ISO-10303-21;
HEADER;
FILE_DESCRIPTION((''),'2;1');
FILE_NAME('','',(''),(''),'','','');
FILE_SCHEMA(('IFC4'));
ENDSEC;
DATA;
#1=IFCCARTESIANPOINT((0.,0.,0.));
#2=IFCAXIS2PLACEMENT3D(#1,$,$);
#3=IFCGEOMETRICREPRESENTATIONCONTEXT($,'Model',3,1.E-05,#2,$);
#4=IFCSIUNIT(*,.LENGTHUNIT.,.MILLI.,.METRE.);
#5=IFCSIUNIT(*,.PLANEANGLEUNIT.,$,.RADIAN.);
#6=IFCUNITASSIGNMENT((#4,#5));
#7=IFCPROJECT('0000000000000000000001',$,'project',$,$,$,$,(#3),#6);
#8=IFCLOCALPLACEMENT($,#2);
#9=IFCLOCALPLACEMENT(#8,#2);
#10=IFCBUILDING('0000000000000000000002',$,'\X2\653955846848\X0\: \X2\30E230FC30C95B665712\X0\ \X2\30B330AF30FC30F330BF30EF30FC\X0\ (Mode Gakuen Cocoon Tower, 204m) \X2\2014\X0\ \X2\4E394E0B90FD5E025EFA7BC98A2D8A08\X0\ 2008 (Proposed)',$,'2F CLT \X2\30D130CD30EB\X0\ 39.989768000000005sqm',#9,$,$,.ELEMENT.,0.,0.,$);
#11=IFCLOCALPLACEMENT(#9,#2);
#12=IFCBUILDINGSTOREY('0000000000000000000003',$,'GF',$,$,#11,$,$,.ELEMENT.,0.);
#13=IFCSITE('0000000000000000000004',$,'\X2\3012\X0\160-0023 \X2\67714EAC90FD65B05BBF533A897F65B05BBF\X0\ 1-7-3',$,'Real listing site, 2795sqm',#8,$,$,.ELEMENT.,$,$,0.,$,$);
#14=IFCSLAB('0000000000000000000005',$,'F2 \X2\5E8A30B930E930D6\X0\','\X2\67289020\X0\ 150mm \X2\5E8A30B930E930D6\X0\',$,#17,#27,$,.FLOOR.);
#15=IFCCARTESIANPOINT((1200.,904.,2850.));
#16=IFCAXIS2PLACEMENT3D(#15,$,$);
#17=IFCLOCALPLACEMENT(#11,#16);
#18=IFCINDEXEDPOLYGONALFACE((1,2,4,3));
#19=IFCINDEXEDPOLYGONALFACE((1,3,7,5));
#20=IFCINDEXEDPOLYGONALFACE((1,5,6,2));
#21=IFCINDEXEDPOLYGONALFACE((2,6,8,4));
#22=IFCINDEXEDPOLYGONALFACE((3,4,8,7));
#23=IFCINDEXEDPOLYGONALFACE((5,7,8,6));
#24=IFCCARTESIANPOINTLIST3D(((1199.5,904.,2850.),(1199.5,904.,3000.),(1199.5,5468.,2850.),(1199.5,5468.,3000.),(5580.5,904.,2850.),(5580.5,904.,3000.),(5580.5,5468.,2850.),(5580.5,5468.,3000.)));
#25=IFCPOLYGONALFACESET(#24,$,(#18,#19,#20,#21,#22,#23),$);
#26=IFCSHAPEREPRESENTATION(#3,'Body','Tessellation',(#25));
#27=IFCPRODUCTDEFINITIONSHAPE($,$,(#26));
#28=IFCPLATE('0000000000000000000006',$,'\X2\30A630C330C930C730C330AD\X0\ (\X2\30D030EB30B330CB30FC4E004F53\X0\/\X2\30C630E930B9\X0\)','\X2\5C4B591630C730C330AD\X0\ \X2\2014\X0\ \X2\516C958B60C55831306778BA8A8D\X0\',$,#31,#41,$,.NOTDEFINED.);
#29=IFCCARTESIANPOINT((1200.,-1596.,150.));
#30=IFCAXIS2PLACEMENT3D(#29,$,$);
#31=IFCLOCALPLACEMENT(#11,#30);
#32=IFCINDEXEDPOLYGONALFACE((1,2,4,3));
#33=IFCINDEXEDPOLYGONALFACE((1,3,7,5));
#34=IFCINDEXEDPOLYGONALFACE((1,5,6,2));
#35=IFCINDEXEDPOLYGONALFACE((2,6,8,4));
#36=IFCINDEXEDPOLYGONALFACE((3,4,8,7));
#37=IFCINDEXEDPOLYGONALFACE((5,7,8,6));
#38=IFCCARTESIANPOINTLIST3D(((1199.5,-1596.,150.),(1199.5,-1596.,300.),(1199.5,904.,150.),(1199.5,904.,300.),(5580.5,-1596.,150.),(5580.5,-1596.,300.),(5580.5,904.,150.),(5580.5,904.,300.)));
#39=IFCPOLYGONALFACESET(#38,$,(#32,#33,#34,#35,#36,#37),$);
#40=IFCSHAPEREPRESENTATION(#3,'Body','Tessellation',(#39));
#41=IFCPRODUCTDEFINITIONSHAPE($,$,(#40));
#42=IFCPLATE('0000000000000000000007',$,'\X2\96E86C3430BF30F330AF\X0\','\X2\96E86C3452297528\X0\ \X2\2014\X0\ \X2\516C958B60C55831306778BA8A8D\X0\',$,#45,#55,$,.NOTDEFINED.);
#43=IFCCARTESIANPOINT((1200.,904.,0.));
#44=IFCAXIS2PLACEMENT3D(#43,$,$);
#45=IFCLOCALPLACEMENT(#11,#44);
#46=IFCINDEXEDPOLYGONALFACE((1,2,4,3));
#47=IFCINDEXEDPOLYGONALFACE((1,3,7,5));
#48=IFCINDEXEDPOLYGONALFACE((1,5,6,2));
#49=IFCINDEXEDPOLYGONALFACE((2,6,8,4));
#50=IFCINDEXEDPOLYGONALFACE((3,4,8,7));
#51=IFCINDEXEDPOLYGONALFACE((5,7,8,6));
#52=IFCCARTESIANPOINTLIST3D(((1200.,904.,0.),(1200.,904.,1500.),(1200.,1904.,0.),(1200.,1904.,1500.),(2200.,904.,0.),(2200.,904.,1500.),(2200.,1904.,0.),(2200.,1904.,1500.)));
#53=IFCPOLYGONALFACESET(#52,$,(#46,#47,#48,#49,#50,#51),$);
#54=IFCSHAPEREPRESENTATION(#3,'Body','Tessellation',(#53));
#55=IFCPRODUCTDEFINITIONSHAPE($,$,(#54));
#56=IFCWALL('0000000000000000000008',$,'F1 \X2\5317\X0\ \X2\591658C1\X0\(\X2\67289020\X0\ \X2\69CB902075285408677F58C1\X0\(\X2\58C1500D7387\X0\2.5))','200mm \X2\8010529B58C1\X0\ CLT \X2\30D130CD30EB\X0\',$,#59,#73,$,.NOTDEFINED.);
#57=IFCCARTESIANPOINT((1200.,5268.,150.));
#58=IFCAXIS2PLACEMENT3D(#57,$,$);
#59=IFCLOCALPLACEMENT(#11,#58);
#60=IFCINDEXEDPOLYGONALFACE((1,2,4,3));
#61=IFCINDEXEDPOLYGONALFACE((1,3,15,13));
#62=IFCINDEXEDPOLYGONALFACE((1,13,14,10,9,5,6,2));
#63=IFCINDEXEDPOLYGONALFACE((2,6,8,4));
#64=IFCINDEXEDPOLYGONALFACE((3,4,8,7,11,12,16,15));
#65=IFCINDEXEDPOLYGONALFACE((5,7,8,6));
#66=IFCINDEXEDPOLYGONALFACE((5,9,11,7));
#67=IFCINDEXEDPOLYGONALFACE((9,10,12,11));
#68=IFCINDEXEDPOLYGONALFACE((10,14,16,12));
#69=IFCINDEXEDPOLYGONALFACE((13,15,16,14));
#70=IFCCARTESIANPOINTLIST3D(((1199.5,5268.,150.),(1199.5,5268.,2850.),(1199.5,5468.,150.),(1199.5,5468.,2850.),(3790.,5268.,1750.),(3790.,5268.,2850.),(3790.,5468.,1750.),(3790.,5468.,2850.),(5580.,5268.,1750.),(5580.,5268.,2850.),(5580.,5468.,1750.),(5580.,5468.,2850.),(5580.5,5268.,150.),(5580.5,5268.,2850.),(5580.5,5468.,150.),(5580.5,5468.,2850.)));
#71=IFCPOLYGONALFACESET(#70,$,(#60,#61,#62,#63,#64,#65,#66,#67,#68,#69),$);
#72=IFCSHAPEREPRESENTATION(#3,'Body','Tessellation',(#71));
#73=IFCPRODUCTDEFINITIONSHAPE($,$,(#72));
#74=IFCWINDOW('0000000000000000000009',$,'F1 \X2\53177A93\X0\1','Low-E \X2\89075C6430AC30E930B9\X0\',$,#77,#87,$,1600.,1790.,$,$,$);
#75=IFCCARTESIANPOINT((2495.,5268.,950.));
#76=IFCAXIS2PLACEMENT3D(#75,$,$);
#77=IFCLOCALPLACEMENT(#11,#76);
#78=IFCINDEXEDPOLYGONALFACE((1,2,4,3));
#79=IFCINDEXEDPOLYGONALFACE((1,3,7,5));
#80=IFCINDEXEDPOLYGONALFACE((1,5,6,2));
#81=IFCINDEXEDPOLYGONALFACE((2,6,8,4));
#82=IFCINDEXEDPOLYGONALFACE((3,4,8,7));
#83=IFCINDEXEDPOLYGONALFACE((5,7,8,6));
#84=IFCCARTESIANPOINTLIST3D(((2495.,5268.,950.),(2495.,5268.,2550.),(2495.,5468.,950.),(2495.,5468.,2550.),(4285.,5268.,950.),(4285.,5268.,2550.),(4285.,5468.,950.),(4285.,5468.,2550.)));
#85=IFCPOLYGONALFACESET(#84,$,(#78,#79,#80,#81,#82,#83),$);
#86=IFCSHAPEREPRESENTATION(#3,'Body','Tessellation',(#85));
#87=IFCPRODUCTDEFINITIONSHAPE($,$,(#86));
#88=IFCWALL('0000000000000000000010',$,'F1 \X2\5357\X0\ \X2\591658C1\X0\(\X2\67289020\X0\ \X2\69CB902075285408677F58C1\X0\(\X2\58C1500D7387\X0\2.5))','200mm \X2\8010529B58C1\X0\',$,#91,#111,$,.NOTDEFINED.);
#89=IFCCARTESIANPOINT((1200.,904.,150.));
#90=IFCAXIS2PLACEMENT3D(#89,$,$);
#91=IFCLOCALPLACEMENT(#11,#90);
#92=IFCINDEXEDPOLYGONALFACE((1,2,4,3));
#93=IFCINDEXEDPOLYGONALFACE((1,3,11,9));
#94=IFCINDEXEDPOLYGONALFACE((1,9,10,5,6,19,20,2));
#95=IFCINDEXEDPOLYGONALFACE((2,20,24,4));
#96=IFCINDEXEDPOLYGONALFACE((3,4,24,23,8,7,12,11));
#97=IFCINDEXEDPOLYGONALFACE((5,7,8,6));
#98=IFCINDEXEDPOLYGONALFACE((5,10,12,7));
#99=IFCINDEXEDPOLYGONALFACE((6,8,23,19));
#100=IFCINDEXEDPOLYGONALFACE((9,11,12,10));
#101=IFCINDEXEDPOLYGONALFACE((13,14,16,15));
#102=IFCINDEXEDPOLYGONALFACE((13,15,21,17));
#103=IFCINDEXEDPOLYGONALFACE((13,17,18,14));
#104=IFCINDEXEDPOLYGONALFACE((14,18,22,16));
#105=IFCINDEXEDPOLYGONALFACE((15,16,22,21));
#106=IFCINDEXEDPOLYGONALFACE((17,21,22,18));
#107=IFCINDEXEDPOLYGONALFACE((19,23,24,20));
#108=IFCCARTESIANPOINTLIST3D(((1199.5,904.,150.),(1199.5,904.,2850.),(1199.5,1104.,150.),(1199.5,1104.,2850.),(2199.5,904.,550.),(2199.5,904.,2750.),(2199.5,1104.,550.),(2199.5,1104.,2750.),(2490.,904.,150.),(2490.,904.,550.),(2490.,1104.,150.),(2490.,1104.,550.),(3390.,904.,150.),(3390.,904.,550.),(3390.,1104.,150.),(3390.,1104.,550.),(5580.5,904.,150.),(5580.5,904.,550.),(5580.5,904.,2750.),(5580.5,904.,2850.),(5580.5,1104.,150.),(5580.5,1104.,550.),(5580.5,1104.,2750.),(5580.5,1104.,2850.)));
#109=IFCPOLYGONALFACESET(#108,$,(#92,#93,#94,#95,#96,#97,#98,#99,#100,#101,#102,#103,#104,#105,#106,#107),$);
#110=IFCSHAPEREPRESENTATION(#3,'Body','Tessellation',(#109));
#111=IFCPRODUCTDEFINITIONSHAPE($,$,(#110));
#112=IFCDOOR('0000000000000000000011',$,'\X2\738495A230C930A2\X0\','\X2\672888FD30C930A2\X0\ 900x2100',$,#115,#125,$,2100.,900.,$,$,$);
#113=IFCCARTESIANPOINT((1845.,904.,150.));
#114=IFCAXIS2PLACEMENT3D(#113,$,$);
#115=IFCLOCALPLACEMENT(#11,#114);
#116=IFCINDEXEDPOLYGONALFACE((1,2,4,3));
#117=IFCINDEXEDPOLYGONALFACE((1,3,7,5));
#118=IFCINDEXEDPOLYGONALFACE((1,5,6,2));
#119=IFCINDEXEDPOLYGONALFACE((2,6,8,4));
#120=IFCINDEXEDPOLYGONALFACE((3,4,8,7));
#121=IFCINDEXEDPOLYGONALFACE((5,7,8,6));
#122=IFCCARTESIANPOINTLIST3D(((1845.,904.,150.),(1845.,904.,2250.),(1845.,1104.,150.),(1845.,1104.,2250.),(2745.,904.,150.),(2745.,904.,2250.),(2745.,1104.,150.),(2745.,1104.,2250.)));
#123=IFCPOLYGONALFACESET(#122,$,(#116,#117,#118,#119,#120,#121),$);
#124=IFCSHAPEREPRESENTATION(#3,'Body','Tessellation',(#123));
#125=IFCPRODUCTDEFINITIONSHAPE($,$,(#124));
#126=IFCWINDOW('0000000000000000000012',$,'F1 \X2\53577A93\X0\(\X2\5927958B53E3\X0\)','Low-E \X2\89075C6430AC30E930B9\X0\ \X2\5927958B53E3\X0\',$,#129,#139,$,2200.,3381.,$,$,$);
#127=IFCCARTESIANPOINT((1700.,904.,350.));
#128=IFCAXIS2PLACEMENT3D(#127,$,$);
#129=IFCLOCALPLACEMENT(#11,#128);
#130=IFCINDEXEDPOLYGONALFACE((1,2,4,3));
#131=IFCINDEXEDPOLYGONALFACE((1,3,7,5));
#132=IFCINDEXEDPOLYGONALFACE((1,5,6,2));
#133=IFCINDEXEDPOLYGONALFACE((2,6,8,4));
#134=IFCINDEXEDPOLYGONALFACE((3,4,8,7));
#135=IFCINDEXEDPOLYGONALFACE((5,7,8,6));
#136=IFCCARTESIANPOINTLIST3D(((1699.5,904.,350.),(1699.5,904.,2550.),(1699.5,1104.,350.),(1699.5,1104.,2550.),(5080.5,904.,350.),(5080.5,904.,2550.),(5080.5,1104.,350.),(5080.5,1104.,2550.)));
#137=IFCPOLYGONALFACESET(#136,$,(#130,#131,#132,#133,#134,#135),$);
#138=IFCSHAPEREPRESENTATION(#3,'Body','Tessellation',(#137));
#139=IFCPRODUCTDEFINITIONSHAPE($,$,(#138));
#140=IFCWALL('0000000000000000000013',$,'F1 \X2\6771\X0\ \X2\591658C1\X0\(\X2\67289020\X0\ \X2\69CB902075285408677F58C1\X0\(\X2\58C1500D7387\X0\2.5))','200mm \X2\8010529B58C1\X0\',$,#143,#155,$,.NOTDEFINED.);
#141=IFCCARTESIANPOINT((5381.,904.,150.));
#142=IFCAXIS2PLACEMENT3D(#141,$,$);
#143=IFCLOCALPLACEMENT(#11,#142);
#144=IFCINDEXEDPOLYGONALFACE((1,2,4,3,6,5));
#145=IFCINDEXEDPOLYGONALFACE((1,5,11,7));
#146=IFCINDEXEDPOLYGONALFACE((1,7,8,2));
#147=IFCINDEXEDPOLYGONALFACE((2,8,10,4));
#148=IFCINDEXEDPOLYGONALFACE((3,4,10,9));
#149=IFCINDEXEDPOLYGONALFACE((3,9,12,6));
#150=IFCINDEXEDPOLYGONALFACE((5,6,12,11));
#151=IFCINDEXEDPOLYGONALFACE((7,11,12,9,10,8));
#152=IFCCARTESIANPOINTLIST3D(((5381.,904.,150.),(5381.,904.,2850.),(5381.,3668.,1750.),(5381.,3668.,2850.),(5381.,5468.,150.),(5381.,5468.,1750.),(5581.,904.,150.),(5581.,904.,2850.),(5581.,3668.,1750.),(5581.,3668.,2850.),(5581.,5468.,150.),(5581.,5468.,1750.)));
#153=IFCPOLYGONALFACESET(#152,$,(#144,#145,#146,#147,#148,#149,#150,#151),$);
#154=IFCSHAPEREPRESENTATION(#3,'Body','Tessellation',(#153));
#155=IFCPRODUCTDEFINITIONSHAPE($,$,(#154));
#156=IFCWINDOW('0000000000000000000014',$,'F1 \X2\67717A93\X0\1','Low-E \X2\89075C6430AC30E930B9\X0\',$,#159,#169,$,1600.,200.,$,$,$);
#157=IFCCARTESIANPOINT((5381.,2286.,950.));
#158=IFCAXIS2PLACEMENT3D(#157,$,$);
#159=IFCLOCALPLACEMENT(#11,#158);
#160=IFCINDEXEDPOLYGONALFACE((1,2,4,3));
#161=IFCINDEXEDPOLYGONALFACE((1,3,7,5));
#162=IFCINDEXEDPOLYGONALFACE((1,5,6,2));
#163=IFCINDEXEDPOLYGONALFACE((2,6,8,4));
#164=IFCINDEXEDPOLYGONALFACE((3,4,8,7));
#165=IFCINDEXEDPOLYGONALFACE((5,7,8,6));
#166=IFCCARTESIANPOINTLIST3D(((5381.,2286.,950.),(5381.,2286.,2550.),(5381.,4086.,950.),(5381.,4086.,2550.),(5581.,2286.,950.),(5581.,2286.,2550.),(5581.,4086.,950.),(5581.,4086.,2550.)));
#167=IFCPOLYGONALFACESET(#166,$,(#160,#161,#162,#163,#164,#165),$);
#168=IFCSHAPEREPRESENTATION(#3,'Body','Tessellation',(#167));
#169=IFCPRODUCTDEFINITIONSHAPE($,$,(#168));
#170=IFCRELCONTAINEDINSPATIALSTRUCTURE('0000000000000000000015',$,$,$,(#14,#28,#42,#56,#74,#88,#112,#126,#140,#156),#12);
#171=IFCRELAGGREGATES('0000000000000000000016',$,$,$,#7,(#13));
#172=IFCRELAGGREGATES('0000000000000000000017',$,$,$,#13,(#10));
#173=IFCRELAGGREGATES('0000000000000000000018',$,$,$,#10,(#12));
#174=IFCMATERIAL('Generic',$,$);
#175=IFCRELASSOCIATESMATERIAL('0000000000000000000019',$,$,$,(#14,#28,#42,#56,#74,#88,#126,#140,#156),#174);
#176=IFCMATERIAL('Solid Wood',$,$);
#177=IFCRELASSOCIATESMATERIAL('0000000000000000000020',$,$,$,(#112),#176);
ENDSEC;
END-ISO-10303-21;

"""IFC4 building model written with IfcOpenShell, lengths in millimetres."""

from ifc_helpers import new_model, si_unit, frame, frame_2d, origin, place, context, project, spatial, rectangle, extrude, material, element, fill, save


model = new_model("IFC4")

# Units and contexts
model_context = context("Model", 3, precision=1e-05, world=origin())
ifc_project = project(units=[si_unit("LENGTHUNIT", "METRE", prefix="MILLI"), si_unit("PLANEANGLEUNIT", "RADIAN")], contexts=[model_context])

# Site, building, storey
site_placement = place(None, origin())
site = spatial("IfcSite", under=ifc_project, at=site_placement, Name="〒160-0023 東京都新宿区西新宿 1-7-3", ObjectType="Real listing site, 2795sqm", CompositionType="ELEMENT", RefElevation=0.0)
building_placement = place(site_placement, origin())
building = spatial("IfcBuilding", under=site, at=building_placement, Name="改善案: モード学園 コクーンタワー (Mode Gakuen Cocoon Tower, 204m) — 丹下都市建築設計 2008 (Proposed)", ObjectType="2F CLT パネル 39.989768000000005sqm", CompositionType="ELEMENT", ElevationOfRefHeight=0.0, ElevationOfTerrain=0.0)
storey_placement = place(building_placement, origin())
storey = spatial("IfcBuildingStorey", under=building, at=storey_placement, Name="GF", CompositionType="ELEMENT", Elevation=0.0)

# Slab
ifc_material_1 = material(Name="Generic")
slab_1_placement = place(storey_placement, frame((1200.0, 904.0, 2850.0)))
element("IfcSlab", 1, at=slab_1_placement, inside=storey, material=ifc_material_1, Name="F2 床スラブ", Description="木造 150mm 床スラブ", PredefinedType="FLOOR", context=model_context, shape_type="SweptSolid", body=[
    extrude(rectangle(XDim=4381.0, YDim=4564.0, at=frame_2d((2190.0, 2282.0))), frame((1200.0, 904.0, 2850.0)), (0.0, 0.0, 1.0), 150.0),
])

# Plates
plate_1_placement = place(storey_placement, frame((1200.0, -1596.0, 150.0)))
element("IfcPlate", 2, at=plate_1_placement, inside=storey, material=ifc_material_1, Name="ウッドデッキ (バルコニー一体/テラス)", Description="屋外デッキ — 公開情報で確認", PredefinedType="NOTDEFINED", context=model_context, shape_type="SweptSolid", body=[
    extrude(rectangle(XDim=4381.0, YDim=2500.0, at=frame_2d((2190.0, 1250.0))), frame((1200.0, -1596.0, 150.0)), (0.0, 0.0, 1.0), 150.0),
])
plate_2_placement = place(storey_placement, frame((1200.0, 904.0, 0.0)))
element("IfcPlate", 3, at=plate_2_placement, inside=storey, material=ifc_material_1, Name="雨水タンク", Description="雨水利用 — 公開情報で確認", PredefinedType="NOTDEFINED", context=model_context, shape_type="SweptSolid", body=[
    extrude(rectangle(XDim=1000.0, YDim=1000.0, at=frame_2d((500.0, 500.0))), frame((1200.0, 904.0, 0.0)), (0.0, 0.0, 1.0), 1500.0),
])

# Wall, opening, window
wall_1_placement = place(storey_placement, frame((1200.0, 5268.0, 150.0)))
wall_1 = element("IfcWall", 4, at=wall_1_placement, inside=storey, material=ifc_material_1, Name="F1 北 外壁(木造 構造用合板壁(壁倍率2.5))", Description="200mm 耐力壁 CLT パネル", PredefinedType="NOTDEFINED", context=model_context, shape_type="SweptSolid", body=[
    extrude(rectangle(XDim=4381.0, YDim=200.0, at=frame_2d((2190.0, 100.0))), frame((1200.0, 5268.0, 150.0)), (0.0, 0.0, 1.0), 2700.0),
])
opening_1_placement = place(storey_placement, frame((2495.0, 5268.0, 950.0)))
opening_1 = element("IfcOpeningElement", 5, at=opening_1_placement, cuts=wall_1, PredefinedType="NOTDEFINED", context=model_context, shape_type="SweptSolid", body=[
    extrude(rectangle(XDim=1790.0, YDim=200.0, at=frame_2d((895.0, 100.0))), frame((2495.0, 5268.0, 950.0)), (0.0, 0.0, 1.0), 1600.0),
])
window_1_placement = place(storey_placement, frame((2495.0, 5268.0, 950.0)))
window_1 = element("IfcWindow", 6, at=window_1_placement, inside=storey, material=ifc_material_1, Name="F1 北窓1", Description="Low-E 複層ガラス", OverallHeight=1600.0, OverallWidth=1790.0, context=model_context, shape_type="SweptSolid", body=[
    extrude(rectangle(XDim=1790.0, YDim=200.0, at=frame_2d((895.0, 100.0))), frame((2495.0, 5268.0, 950.0)), (0.0, 0.0, 1.0), 1600.0),
])
fill(opening_1, window_1)

# Wall, openings, door, window
wall_2_placement = place(storey_placement, frame((1200.0, 904.0, 150.0)))
wall_2 = element("IfcWall", 7, at=wall_2_placement, inside=storey, material=ifc_material_1, Name="F1 南 外壁(木造 構造用合板壁(壁倍率2.5))", Description="200mm 耐力壁", PredefinedType="NOTDEFINED", context=model_context, shape_type="SweptSolid", body=[
    extrude(rectangle(XDim=4381.0, YDim=200.0, at=frame_2d((2190.0, 100.0))), frame((1200.0, 904.0, 150.0)), (0.0, 0.0, 1.0), 2700.0),
])
opening_2_placement = place(storey_placement, frame((1845.0, 904.0, 150.0)))
opening_2 = element("IfcOpeningElement", 8, at=opening_2_placement, cuts=wall_2, PredefinedType="NOTDEFINED", context=model_context, shape_type="SweptSolid", body=[
    extrude(rectangle(XDim=900.0, YDim=200.0, at=frame_2d((450.0, 100.0))), frame((1845.0, 904.0, 150.0)), (0.0, 0.0, 1.0), 2100.0),
])
opening_3_placement = place(storey_placement, frame((1700.0, 904.0, 350.0)))
opening_3 = element("IfcOpeningElement", 9, at=opening_3_placement, cuts=wall_2, PredefinedType="NOTDEFINED", context=model_context, shape_type="SweptSolid", body=[
    extrude(rectangle(XDim=3381.0, YDim=200.0, at=frame_2d((1690.0, 100.0))), frame((1700.0, 904.0, 350.0)), (0.0, 0.0, 1.0), 2200.0),
])
ifc_material_2 = material(Name="Solid Wood")
door_placement = place(storey_placement, frame((1845.0, 904.0, 150.0)))
door = element("IfcDoor", 10, at=door_placement, inside=storey, material=ifc_material_2, Name="玄関ドア", Description="木製ドア 900x2100", OverallHeight=2100.0, OverallWidth=900.0, context=model_context, shape_type="SweptSolid", body=[
    extrude(rectangle(XDim=900.0, YDim=200.0, at=frame_2d((450.0, 100.0))), frame((1845.0, 904.0, 150.0)), (0.0, 0.0, 1.0), 2100.0),
])
fill(opening_2, door)
window_2_placement = place(storey_placement, frame((1700.0, 904.0, 350.0)))
window_2 = element("IfcWindow", 11, at=window_2_placement, inside=storey, material=ifc_material_1, Name="F1 南窓(大開口)", Description="Low-E 複層ガラス 大開口", OverallHeight=2200.0, OverallWidth=3381.0, context=model_context, shape_type="SweptSolid", body=[
    extrude(rectangle(XDim=3381.0, YDim=200.0, at=frame_2d((1690.0, 100.0))), frame((1700.0, 904.0, 350.0)), (0.0, 0.0, 1.0), 2200.0),
])
fill(opening_3, window_2)

# Wall, opening, window
wall_3_placement = place(storey_placement, frame((5381.0, 904.0, 150.0)))
wall_3 = element("IfcWall", 12, at=wall_3_placement, inside=storey, material=ifc_material_1, Name="F1 東 外壁(木造 構造用合板壁(壁倍率2.5))", Description="200mm 耐力壁", PredefinedType="NOTDEFINED", context=model_context, shape_type="SweptSolid", body=[
    extrude(rectangle(XDim=200.0, YDim=4564.0, at=frame_2d((100.0, 2282.0))), frame((5381.0, 904.0, 150.0)), (0.0, 0.0, 1.0), 2700.0),
])
opening_4_placement = place(storey_placement, frame((5381.0, 2286.0, 950.0)))
opening_4 = element("IfcOpeningElement", 13, at=opening_4_placement, cuts=wall_3, PredefinedType="NOTDEFINED", context=model_context, shape_type="SweptSolid", body=[
    extrude(rectangle(XDim=200.0, YDim=1800.0, at=frame_2d((100.0, 900.0))), frame((5381.0, 2286.0, 950.0)), (0.0, 0.0, 1.0), 1600.0),
])
window_3_placement = place(storey_placement, frame((5381.0, 2286.0, 950.0)))
window_3 = element("IfcWindow", 14, at=window_3_placement, inside=storey, material=ifc_material_1, Name="F1 東窓1", Description="Low-E 複層ガラス", OverallHeight=1600.0, OverallWidth=200.0, context=model_context, shape_type="SweptSolid", body=[
    extrude(rectangle(XDim=200.0, YDim=1800.0, at=frame_2d((100.0, 900.0))), frame((5381.0, 2286.0, 950.0)), (0.0, 0.0, 1.0), 1600.0),
])
fill(opening_4, window_3)

save(model, "model.ifc")
